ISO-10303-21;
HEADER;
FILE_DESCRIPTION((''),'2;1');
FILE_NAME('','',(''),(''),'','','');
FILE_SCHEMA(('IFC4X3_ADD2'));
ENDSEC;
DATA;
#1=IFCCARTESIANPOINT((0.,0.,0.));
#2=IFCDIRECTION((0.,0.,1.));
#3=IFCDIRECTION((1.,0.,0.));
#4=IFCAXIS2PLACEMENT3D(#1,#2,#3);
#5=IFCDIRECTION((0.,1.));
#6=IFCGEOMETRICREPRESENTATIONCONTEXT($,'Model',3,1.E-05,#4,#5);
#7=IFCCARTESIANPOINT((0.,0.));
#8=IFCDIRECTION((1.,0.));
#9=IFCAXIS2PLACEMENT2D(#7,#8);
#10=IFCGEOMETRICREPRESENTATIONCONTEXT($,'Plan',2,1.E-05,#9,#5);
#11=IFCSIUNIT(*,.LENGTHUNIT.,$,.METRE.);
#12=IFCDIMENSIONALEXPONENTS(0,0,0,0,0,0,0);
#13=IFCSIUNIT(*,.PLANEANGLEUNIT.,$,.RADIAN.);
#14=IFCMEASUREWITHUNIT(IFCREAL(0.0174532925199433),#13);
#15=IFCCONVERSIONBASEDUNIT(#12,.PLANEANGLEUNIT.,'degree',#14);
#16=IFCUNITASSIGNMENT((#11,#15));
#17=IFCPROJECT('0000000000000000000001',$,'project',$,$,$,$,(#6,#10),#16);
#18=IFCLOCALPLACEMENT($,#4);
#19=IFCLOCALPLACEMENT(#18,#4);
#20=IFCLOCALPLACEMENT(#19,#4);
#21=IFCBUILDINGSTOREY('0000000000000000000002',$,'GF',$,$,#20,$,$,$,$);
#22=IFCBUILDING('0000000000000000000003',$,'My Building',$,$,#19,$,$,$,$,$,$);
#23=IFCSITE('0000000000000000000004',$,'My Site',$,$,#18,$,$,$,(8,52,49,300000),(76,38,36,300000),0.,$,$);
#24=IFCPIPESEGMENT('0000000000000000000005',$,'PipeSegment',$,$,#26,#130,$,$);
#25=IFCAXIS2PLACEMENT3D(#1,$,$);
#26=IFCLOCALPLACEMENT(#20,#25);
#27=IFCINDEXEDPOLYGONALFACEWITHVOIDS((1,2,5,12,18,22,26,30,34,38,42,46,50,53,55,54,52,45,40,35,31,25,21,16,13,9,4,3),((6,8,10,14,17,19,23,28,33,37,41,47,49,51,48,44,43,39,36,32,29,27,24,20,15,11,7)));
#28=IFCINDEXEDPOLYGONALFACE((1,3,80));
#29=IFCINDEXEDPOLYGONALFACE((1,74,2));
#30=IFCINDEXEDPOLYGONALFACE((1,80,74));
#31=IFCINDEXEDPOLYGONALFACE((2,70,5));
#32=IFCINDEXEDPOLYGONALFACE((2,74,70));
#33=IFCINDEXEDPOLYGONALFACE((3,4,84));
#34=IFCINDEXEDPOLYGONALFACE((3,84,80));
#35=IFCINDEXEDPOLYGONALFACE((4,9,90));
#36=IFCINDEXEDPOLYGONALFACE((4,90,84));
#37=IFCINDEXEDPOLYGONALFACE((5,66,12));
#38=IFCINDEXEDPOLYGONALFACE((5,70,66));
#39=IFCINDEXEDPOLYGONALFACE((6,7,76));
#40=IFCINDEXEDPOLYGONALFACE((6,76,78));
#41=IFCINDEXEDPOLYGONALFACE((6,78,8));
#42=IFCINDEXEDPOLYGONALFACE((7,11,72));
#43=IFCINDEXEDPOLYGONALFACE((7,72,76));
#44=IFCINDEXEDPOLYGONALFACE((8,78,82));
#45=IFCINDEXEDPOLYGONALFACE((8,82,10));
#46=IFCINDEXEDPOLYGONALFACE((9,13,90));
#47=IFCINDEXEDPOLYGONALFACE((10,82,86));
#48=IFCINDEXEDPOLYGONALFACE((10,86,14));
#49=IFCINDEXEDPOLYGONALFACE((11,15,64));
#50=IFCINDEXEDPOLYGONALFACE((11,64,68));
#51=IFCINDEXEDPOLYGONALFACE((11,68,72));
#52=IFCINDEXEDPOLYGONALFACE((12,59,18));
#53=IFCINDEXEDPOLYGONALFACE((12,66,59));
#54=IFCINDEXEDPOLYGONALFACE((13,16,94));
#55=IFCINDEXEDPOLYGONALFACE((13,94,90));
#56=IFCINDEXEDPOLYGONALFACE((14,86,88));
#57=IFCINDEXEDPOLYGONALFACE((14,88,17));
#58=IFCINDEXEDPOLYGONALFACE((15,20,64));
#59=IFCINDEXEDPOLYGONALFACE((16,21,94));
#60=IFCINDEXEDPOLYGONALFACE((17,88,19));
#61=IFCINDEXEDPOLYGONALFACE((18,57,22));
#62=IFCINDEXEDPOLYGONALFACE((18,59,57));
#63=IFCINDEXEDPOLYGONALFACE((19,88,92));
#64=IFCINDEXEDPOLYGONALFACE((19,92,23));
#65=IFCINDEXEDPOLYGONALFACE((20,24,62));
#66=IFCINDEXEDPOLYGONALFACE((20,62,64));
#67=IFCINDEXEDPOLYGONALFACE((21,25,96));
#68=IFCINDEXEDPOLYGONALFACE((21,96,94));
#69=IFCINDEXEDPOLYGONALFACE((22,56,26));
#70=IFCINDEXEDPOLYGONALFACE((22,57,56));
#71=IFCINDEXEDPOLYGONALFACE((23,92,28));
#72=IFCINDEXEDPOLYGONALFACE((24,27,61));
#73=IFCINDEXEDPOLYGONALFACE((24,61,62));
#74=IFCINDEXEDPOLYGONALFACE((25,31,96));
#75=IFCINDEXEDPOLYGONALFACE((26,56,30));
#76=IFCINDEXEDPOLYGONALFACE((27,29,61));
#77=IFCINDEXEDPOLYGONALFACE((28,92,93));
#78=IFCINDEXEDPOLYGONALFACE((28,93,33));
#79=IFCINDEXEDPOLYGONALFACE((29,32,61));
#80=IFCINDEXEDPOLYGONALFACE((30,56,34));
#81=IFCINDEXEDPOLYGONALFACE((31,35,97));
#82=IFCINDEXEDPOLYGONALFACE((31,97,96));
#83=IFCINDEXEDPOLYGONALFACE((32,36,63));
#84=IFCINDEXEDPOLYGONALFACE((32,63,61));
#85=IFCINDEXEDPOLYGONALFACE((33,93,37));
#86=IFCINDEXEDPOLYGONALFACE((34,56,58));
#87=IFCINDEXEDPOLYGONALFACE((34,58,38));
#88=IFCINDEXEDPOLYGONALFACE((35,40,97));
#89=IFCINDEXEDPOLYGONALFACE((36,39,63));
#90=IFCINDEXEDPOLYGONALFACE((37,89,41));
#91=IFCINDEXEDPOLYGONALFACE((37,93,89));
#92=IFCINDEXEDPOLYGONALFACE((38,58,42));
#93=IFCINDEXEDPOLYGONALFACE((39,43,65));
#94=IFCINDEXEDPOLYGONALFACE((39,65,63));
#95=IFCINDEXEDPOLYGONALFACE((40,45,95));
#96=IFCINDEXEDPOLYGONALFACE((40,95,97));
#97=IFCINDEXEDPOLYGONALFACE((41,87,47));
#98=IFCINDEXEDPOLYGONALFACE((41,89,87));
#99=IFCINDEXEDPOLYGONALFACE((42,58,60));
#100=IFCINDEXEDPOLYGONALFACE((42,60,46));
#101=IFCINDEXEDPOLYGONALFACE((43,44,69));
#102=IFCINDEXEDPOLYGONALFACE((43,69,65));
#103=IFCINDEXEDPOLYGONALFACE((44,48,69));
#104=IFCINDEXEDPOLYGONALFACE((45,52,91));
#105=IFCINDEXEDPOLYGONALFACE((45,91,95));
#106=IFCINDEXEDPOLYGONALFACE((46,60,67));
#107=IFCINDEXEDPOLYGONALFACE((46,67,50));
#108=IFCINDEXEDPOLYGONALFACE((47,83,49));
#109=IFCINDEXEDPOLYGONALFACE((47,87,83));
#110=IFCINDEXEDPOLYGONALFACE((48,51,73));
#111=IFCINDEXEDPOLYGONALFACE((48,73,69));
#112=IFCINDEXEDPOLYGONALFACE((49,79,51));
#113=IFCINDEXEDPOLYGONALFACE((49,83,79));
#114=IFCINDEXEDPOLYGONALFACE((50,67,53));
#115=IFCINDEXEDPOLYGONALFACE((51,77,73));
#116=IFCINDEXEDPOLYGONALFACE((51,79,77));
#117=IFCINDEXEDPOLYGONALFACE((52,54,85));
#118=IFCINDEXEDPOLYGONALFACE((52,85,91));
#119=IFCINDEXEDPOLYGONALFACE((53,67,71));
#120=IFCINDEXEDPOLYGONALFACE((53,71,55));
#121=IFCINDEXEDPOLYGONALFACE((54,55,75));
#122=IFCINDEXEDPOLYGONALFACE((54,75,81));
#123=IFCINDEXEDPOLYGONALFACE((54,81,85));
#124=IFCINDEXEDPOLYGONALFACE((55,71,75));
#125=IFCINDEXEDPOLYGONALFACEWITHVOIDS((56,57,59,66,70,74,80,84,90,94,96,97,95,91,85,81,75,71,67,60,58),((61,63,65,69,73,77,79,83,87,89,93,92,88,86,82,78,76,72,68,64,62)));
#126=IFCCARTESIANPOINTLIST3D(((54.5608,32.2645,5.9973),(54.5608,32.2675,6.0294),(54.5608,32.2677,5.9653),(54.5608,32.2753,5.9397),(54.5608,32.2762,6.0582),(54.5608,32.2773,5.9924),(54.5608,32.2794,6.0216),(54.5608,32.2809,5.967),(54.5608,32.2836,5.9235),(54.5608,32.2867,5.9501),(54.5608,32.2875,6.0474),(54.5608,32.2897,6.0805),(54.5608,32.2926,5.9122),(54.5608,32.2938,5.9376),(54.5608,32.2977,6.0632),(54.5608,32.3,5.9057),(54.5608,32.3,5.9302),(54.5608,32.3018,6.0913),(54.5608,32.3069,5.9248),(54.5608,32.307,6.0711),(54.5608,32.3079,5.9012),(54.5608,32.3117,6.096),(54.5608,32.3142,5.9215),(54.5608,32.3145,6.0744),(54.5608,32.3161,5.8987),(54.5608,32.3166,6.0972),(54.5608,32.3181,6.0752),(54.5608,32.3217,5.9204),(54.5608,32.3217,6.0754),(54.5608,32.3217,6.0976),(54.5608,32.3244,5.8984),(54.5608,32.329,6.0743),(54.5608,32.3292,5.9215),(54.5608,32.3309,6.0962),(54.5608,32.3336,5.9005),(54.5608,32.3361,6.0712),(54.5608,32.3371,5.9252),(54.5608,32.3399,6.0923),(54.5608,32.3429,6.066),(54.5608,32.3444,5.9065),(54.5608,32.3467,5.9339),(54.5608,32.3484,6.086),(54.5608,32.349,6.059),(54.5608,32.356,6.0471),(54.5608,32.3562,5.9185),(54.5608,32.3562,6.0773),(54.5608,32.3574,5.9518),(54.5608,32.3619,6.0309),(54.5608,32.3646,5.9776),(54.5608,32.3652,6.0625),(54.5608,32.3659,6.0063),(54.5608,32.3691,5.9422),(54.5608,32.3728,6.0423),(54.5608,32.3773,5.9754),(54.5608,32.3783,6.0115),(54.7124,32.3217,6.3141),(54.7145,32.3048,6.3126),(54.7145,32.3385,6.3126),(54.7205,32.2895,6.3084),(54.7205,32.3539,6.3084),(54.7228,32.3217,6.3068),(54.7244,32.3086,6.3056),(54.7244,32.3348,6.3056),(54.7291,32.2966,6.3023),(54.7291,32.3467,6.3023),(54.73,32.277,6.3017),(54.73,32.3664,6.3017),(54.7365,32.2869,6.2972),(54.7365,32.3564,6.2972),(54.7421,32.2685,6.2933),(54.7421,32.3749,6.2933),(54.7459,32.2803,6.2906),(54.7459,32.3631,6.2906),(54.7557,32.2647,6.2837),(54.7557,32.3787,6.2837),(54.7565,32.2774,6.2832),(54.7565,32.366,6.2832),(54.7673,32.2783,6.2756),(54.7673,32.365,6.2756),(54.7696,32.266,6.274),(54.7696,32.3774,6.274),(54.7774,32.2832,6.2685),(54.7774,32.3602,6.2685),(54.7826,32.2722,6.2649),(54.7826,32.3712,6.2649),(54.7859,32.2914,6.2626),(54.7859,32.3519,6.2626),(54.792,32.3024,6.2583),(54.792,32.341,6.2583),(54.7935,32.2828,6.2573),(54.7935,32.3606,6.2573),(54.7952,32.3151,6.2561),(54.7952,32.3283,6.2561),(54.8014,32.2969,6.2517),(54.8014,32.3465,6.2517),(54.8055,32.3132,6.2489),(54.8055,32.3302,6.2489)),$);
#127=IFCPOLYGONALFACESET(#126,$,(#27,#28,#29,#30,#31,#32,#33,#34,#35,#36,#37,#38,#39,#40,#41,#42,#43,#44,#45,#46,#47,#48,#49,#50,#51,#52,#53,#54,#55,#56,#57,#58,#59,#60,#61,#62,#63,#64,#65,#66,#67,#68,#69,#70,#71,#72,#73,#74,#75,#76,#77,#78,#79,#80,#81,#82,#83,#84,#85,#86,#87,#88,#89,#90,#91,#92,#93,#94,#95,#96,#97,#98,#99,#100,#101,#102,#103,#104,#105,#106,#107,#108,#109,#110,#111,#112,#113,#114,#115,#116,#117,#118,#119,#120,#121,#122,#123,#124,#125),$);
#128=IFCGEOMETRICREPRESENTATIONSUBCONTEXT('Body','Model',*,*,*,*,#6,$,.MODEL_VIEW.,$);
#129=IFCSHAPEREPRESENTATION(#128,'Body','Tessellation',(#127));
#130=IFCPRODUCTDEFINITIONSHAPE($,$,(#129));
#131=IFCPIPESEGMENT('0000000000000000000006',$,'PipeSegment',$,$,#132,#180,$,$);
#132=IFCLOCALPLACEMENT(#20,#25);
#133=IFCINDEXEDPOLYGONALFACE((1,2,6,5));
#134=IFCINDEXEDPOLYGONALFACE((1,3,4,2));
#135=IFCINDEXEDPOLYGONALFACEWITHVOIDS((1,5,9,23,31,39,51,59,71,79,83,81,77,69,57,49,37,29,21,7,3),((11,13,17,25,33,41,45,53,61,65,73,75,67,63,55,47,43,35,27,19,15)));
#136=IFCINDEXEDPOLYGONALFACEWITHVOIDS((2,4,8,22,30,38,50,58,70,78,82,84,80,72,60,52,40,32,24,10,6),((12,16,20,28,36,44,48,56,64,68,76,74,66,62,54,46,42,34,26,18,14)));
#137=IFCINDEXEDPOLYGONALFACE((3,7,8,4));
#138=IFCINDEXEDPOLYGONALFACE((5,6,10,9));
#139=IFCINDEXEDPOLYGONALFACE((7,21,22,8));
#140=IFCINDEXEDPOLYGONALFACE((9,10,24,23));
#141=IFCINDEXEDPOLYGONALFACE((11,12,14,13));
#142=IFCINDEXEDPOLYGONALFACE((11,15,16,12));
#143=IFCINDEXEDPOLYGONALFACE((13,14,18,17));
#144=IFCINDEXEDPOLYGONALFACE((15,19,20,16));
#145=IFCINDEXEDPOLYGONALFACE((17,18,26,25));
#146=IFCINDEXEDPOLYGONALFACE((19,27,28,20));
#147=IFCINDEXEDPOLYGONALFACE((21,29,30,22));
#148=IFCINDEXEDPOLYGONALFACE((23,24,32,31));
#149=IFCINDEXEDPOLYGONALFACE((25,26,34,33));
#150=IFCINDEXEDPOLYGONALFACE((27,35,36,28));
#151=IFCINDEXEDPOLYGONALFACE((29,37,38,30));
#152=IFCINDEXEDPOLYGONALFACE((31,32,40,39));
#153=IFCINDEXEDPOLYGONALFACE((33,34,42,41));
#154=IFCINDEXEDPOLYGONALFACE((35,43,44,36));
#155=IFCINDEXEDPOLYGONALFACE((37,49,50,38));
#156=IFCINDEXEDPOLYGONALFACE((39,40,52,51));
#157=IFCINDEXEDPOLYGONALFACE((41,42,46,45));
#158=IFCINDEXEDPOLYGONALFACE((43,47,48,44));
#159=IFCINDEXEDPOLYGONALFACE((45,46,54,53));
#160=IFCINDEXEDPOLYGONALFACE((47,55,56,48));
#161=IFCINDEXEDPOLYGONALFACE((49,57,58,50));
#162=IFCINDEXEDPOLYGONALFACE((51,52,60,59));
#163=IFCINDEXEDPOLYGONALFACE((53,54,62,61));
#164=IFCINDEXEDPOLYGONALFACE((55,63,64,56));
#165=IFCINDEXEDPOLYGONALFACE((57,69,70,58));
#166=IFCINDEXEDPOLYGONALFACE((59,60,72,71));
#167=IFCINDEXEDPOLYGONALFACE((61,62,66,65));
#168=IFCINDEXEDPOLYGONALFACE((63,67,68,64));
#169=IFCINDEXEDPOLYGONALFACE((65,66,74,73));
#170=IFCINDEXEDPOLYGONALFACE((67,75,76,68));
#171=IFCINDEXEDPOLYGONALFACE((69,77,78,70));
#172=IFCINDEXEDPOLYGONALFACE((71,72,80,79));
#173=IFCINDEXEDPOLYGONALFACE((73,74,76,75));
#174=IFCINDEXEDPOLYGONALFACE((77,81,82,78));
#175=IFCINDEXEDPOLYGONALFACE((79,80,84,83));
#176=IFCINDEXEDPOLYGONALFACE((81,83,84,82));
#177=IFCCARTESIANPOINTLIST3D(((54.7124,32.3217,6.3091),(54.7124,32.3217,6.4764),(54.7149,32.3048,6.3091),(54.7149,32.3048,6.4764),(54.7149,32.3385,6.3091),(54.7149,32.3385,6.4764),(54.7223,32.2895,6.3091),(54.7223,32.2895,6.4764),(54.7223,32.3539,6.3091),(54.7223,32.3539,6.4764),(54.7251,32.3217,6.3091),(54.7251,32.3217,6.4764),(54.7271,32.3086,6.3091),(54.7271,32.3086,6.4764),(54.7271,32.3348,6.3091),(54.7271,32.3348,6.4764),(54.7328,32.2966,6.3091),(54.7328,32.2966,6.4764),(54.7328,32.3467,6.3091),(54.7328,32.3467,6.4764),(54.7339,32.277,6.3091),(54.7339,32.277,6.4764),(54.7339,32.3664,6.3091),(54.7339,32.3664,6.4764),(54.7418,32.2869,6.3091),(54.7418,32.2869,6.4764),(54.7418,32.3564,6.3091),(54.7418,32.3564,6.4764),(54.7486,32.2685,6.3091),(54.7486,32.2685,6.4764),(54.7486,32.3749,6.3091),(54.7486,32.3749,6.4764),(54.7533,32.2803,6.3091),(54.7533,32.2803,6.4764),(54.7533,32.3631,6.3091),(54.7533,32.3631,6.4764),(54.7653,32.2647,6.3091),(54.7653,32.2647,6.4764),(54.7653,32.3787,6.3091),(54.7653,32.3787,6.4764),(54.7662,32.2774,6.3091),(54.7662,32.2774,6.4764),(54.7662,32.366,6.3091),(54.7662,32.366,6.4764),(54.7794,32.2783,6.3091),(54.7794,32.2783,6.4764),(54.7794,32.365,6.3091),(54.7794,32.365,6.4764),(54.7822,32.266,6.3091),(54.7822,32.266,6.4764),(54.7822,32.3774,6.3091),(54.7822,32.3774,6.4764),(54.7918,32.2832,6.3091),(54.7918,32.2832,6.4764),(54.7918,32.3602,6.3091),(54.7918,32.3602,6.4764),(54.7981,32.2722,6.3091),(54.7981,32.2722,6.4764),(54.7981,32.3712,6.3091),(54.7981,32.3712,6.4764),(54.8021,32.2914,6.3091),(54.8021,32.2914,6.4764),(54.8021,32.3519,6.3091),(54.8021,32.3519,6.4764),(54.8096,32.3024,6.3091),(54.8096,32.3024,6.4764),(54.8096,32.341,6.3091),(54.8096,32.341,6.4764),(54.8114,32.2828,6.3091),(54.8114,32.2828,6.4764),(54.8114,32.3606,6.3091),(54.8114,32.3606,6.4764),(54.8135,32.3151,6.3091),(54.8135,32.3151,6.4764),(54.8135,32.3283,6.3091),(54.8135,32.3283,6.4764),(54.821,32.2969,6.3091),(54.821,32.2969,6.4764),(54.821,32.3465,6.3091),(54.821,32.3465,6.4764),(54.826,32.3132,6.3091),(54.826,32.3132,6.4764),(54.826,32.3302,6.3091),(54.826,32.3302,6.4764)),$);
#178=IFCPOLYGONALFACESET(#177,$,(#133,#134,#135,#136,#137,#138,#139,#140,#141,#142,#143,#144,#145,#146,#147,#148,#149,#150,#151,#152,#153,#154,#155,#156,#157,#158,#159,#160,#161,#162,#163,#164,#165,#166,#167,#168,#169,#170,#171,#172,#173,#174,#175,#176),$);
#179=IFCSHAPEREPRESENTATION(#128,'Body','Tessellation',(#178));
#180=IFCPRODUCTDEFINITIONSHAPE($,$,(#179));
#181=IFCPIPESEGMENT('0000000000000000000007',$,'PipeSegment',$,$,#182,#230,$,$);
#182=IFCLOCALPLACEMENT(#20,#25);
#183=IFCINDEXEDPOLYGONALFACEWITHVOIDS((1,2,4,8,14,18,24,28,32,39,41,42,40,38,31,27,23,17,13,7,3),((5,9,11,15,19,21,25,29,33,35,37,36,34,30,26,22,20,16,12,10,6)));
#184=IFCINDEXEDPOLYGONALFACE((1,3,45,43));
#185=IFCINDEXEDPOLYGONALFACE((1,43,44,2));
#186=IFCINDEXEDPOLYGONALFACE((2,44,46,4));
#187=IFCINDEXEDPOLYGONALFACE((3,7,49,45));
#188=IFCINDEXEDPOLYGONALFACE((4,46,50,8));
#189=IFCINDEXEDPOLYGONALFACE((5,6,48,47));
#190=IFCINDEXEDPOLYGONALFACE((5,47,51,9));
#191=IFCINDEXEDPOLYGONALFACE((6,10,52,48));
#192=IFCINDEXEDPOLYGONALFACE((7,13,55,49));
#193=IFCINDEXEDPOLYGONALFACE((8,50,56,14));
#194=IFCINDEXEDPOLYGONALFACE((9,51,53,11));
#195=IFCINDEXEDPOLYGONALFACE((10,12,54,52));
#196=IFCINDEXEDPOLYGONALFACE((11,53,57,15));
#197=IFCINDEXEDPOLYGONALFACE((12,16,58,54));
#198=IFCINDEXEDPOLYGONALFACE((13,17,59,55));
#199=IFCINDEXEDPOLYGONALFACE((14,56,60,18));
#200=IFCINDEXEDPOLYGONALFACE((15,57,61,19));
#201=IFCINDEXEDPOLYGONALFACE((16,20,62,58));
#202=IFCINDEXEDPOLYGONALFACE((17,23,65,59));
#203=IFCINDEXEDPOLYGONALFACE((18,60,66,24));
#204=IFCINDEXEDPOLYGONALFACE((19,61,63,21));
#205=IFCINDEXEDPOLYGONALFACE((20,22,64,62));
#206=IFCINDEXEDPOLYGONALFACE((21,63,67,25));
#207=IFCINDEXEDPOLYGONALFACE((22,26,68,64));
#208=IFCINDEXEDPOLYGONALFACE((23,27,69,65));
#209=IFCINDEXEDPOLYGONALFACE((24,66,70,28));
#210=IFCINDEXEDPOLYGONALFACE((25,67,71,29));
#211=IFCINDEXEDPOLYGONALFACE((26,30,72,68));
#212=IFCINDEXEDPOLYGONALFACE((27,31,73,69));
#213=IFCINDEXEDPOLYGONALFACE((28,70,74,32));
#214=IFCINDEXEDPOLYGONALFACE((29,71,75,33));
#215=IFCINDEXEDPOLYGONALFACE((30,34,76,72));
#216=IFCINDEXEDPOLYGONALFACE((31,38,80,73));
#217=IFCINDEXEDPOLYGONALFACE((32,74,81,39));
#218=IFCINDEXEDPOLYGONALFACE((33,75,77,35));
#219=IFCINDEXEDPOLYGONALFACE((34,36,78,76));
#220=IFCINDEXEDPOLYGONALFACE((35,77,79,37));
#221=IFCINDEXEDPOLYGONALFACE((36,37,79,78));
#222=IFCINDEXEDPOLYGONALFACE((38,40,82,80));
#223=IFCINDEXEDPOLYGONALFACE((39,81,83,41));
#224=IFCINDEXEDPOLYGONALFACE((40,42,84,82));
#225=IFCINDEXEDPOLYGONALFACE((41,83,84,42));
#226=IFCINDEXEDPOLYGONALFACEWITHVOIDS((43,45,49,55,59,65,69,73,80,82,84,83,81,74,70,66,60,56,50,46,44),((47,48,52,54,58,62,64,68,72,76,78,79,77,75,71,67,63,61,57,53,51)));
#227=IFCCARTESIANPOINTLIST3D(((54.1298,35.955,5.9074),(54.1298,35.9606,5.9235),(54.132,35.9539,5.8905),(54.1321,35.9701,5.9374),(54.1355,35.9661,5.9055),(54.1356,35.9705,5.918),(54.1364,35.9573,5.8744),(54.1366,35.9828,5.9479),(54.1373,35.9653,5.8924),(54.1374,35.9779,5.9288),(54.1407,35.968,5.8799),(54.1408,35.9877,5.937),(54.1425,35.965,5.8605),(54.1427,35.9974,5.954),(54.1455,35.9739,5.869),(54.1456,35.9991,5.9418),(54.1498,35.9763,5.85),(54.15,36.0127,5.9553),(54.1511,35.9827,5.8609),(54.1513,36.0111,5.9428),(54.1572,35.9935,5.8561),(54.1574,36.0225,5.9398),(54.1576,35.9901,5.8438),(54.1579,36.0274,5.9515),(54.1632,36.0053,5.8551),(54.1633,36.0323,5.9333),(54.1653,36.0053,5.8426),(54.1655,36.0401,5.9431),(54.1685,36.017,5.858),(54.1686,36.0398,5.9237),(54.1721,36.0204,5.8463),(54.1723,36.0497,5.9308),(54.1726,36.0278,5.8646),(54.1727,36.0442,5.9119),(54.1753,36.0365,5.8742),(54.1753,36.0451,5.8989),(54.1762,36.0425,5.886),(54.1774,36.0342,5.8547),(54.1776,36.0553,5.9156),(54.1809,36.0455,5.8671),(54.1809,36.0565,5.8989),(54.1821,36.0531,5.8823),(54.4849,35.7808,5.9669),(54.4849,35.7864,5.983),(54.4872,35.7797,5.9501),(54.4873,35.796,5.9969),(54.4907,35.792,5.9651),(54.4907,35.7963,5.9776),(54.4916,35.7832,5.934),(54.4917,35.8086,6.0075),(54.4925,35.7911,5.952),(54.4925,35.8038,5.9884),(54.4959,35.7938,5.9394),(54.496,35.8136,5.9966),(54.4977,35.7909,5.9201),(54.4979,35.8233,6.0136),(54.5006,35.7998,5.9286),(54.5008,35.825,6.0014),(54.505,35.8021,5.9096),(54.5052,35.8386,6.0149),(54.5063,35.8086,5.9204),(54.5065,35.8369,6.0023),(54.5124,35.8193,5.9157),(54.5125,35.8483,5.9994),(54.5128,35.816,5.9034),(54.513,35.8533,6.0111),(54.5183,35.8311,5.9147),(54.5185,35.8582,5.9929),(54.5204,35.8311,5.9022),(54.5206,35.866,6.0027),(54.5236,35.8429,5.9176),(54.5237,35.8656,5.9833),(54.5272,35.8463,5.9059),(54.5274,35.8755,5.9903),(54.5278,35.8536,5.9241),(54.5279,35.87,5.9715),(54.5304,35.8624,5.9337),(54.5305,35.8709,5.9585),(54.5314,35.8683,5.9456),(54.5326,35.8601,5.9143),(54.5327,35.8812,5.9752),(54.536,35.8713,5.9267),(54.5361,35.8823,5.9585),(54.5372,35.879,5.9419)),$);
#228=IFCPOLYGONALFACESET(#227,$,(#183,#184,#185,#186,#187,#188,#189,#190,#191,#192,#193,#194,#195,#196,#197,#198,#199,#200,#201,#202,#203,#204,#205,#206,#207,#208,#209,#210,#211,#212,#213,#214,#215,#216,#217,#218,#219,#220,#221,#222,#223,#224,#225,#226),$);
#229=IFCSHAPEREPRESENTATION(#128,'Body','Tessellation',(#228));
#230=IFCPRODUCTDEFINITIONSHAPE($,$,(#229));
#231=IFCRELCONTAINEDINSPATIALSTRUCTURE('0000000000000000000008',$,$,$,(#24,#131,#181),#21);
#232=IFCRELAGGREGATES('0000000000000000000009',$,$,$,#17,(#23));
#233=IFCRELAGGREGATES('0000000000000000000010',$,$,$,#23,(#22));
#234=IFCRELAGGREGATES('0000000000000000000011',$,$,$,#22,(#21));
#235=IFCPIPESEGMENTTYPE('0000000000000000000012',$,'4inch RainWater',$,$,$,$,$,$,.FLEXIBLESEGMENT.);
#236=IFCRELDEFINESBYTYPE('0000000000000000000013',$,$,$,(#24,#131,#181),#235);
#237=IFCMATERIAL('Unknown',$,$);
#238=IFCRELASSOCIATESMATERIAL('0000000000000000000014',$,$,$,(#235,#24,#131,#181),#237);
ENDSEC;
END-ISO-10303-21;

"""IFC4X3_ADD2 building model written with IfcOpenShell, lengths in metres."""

from ifc_helpers import new_model, entity, si_unit, converted_unit, direction, frame, origin_with_axes, origin_2d_with_axis, place, context, subcontext, project, spatial, hollow_circle, extrude, clip, halfspace, material, material_profile, profile_set, profile_usage, type_object, element, save


model = new_model("IFC4X3_ADD2")

# Units and contexts
model_context = context("Model", 3, precision=1e-05, world=origin_with_axes(), true_north=direction((0.0, 1.0)))
plan_context = context("Plan", 2, precision=1e-05, world=origin_2d_with_axis(), true_north=direction((0.0, 1.0)))
body_context_1 = subcontext(model_context, "Body", "Model", "MODEL_VIEW")
ifc_project = project(units=[si_unit("LENGTHUNIT", "METRE"), converted_unit("PLANEANGLEUNIT", "degree", entity("IfcReal", 0.0174532925199433), si_unit("PLANEANGLEUNIT", "RADIAN"), dimensions=[0, 0, 0, 0, 0, 0, 0])], contexts=[model_context, plan_context])

# Site, building, storey
site_placement = place(None, origin_with_axes())
site = spatial("IfcSite", under=ifc_project, at=site_placement, Name="My Site", RefLatitude=(8, 52, 49, 300000), RefLongitude=(76, 38, 36, 300000), RefElevation=0.0)
building_placement = place(site_placement, origin_with_axes())
building = spatial("IfcBuilding", under=site, at=building_placement, Name="My Building")
storey_placement = place(building_placement, origin_with_axes())
storey = spatial("IfcBuildingStorey", under=building, at=storey_placement, Name="GF")

# Shared definitions
ifc_material_1 = material(Name="Unknown")

# Pipe segments
ifc_material_profile_1 = material_profile(ifc_material_1, hollow_circle(Radius=0.0571, WallThickness=0.0127))
ifc_profile_set_1 = profile_set([ifc_material_profile_1], Name="rainwater")
ifc_profile_usage_1 = profile_usage(ifc_profile_set_1, cardinal=5)
pipe_segment_type = type_object("IfcPipeSegmentType", Name="4inch RainWater", PredefinedType="FLEXIBLESEGMENT", material=ifc_profile_set_1)
pipe_segment_1_placement = place(storey_placement, frame((54.7592, 32.3217, 6.2813), z_axis=(-0.573576, 0.0, -0.819152), x_axis=(-0.819152, 0.0, 0.573576)))
element("IfcPipeSegment", 1, at=pipe_segment_1_placement, inside=storey, type_object=pipe_segment_type, material=ifc_profile_usage_1, Name="PipeSegment", context=body_context_1, shape_type="Clipping", body=[
    clip(extrude(hollow_circle(Radius=0.0571, WallThickness=0.0127), origin_with_axes(), (0.0, 0.0, 1.0), 0.4602), halfspace(frame((0.0759, 0.0, 0.2375), z_axis=(0.819152, 0.0, 0.573576), x_axis=(0.0, -1.0, 0.0)), False)),
])
ifc_profile_usage_2 = profile_usage(ifc_profile_set_1, cardinal=5)
pipe_segment_2_placement = place(storey_placement, frame((54.7695, 32.3217, 6.4764), z_axis=(0.0, 0.0, -1.0), x_axis=(-1.0, 0.0, 0.0)))
element("IfcPipeSegment", 2, at=pipe_segment_2_placement, inside=storey, type_object=pipe_segment_type, material=ifc_profile_usage_2, Name="PipeSegment", context=body_context_1, shape_type="SweptSolid", body=[
    extrude(hollow_circle(Radius=0.0571, WallThickness=0.0127), origin_with_axes(), (0.0, 0.0, 1.0), 0.1673),
])
ifc_profile_usage_3 = profile_usage(ifc_profile_set_1, cardinal=5)
pipe_segment_3_placement = place(storey_placement, frame((54.1558, 36.0052, 5.8989), z_axis=(0.887848, -0.435364, 0.148942), x_axis=(0.440274, 0.897863, 0.0)))
element("IfcPipeSegment", 3, at=pipe_segment_3_placement, inside=storey, type_object=pipe_segment_type, material=ifc_profile_usage_3, Name="PipeSegment", context=body_context_1, shape_type="SweptSolid", body=[
    extrude(hollow_circle(Radius=0.0571, WallThickness=0.0127), origin_with_axes(), (0.0, 0.0, 1.0), 0.4),
])

save(model, "model.ifc")
